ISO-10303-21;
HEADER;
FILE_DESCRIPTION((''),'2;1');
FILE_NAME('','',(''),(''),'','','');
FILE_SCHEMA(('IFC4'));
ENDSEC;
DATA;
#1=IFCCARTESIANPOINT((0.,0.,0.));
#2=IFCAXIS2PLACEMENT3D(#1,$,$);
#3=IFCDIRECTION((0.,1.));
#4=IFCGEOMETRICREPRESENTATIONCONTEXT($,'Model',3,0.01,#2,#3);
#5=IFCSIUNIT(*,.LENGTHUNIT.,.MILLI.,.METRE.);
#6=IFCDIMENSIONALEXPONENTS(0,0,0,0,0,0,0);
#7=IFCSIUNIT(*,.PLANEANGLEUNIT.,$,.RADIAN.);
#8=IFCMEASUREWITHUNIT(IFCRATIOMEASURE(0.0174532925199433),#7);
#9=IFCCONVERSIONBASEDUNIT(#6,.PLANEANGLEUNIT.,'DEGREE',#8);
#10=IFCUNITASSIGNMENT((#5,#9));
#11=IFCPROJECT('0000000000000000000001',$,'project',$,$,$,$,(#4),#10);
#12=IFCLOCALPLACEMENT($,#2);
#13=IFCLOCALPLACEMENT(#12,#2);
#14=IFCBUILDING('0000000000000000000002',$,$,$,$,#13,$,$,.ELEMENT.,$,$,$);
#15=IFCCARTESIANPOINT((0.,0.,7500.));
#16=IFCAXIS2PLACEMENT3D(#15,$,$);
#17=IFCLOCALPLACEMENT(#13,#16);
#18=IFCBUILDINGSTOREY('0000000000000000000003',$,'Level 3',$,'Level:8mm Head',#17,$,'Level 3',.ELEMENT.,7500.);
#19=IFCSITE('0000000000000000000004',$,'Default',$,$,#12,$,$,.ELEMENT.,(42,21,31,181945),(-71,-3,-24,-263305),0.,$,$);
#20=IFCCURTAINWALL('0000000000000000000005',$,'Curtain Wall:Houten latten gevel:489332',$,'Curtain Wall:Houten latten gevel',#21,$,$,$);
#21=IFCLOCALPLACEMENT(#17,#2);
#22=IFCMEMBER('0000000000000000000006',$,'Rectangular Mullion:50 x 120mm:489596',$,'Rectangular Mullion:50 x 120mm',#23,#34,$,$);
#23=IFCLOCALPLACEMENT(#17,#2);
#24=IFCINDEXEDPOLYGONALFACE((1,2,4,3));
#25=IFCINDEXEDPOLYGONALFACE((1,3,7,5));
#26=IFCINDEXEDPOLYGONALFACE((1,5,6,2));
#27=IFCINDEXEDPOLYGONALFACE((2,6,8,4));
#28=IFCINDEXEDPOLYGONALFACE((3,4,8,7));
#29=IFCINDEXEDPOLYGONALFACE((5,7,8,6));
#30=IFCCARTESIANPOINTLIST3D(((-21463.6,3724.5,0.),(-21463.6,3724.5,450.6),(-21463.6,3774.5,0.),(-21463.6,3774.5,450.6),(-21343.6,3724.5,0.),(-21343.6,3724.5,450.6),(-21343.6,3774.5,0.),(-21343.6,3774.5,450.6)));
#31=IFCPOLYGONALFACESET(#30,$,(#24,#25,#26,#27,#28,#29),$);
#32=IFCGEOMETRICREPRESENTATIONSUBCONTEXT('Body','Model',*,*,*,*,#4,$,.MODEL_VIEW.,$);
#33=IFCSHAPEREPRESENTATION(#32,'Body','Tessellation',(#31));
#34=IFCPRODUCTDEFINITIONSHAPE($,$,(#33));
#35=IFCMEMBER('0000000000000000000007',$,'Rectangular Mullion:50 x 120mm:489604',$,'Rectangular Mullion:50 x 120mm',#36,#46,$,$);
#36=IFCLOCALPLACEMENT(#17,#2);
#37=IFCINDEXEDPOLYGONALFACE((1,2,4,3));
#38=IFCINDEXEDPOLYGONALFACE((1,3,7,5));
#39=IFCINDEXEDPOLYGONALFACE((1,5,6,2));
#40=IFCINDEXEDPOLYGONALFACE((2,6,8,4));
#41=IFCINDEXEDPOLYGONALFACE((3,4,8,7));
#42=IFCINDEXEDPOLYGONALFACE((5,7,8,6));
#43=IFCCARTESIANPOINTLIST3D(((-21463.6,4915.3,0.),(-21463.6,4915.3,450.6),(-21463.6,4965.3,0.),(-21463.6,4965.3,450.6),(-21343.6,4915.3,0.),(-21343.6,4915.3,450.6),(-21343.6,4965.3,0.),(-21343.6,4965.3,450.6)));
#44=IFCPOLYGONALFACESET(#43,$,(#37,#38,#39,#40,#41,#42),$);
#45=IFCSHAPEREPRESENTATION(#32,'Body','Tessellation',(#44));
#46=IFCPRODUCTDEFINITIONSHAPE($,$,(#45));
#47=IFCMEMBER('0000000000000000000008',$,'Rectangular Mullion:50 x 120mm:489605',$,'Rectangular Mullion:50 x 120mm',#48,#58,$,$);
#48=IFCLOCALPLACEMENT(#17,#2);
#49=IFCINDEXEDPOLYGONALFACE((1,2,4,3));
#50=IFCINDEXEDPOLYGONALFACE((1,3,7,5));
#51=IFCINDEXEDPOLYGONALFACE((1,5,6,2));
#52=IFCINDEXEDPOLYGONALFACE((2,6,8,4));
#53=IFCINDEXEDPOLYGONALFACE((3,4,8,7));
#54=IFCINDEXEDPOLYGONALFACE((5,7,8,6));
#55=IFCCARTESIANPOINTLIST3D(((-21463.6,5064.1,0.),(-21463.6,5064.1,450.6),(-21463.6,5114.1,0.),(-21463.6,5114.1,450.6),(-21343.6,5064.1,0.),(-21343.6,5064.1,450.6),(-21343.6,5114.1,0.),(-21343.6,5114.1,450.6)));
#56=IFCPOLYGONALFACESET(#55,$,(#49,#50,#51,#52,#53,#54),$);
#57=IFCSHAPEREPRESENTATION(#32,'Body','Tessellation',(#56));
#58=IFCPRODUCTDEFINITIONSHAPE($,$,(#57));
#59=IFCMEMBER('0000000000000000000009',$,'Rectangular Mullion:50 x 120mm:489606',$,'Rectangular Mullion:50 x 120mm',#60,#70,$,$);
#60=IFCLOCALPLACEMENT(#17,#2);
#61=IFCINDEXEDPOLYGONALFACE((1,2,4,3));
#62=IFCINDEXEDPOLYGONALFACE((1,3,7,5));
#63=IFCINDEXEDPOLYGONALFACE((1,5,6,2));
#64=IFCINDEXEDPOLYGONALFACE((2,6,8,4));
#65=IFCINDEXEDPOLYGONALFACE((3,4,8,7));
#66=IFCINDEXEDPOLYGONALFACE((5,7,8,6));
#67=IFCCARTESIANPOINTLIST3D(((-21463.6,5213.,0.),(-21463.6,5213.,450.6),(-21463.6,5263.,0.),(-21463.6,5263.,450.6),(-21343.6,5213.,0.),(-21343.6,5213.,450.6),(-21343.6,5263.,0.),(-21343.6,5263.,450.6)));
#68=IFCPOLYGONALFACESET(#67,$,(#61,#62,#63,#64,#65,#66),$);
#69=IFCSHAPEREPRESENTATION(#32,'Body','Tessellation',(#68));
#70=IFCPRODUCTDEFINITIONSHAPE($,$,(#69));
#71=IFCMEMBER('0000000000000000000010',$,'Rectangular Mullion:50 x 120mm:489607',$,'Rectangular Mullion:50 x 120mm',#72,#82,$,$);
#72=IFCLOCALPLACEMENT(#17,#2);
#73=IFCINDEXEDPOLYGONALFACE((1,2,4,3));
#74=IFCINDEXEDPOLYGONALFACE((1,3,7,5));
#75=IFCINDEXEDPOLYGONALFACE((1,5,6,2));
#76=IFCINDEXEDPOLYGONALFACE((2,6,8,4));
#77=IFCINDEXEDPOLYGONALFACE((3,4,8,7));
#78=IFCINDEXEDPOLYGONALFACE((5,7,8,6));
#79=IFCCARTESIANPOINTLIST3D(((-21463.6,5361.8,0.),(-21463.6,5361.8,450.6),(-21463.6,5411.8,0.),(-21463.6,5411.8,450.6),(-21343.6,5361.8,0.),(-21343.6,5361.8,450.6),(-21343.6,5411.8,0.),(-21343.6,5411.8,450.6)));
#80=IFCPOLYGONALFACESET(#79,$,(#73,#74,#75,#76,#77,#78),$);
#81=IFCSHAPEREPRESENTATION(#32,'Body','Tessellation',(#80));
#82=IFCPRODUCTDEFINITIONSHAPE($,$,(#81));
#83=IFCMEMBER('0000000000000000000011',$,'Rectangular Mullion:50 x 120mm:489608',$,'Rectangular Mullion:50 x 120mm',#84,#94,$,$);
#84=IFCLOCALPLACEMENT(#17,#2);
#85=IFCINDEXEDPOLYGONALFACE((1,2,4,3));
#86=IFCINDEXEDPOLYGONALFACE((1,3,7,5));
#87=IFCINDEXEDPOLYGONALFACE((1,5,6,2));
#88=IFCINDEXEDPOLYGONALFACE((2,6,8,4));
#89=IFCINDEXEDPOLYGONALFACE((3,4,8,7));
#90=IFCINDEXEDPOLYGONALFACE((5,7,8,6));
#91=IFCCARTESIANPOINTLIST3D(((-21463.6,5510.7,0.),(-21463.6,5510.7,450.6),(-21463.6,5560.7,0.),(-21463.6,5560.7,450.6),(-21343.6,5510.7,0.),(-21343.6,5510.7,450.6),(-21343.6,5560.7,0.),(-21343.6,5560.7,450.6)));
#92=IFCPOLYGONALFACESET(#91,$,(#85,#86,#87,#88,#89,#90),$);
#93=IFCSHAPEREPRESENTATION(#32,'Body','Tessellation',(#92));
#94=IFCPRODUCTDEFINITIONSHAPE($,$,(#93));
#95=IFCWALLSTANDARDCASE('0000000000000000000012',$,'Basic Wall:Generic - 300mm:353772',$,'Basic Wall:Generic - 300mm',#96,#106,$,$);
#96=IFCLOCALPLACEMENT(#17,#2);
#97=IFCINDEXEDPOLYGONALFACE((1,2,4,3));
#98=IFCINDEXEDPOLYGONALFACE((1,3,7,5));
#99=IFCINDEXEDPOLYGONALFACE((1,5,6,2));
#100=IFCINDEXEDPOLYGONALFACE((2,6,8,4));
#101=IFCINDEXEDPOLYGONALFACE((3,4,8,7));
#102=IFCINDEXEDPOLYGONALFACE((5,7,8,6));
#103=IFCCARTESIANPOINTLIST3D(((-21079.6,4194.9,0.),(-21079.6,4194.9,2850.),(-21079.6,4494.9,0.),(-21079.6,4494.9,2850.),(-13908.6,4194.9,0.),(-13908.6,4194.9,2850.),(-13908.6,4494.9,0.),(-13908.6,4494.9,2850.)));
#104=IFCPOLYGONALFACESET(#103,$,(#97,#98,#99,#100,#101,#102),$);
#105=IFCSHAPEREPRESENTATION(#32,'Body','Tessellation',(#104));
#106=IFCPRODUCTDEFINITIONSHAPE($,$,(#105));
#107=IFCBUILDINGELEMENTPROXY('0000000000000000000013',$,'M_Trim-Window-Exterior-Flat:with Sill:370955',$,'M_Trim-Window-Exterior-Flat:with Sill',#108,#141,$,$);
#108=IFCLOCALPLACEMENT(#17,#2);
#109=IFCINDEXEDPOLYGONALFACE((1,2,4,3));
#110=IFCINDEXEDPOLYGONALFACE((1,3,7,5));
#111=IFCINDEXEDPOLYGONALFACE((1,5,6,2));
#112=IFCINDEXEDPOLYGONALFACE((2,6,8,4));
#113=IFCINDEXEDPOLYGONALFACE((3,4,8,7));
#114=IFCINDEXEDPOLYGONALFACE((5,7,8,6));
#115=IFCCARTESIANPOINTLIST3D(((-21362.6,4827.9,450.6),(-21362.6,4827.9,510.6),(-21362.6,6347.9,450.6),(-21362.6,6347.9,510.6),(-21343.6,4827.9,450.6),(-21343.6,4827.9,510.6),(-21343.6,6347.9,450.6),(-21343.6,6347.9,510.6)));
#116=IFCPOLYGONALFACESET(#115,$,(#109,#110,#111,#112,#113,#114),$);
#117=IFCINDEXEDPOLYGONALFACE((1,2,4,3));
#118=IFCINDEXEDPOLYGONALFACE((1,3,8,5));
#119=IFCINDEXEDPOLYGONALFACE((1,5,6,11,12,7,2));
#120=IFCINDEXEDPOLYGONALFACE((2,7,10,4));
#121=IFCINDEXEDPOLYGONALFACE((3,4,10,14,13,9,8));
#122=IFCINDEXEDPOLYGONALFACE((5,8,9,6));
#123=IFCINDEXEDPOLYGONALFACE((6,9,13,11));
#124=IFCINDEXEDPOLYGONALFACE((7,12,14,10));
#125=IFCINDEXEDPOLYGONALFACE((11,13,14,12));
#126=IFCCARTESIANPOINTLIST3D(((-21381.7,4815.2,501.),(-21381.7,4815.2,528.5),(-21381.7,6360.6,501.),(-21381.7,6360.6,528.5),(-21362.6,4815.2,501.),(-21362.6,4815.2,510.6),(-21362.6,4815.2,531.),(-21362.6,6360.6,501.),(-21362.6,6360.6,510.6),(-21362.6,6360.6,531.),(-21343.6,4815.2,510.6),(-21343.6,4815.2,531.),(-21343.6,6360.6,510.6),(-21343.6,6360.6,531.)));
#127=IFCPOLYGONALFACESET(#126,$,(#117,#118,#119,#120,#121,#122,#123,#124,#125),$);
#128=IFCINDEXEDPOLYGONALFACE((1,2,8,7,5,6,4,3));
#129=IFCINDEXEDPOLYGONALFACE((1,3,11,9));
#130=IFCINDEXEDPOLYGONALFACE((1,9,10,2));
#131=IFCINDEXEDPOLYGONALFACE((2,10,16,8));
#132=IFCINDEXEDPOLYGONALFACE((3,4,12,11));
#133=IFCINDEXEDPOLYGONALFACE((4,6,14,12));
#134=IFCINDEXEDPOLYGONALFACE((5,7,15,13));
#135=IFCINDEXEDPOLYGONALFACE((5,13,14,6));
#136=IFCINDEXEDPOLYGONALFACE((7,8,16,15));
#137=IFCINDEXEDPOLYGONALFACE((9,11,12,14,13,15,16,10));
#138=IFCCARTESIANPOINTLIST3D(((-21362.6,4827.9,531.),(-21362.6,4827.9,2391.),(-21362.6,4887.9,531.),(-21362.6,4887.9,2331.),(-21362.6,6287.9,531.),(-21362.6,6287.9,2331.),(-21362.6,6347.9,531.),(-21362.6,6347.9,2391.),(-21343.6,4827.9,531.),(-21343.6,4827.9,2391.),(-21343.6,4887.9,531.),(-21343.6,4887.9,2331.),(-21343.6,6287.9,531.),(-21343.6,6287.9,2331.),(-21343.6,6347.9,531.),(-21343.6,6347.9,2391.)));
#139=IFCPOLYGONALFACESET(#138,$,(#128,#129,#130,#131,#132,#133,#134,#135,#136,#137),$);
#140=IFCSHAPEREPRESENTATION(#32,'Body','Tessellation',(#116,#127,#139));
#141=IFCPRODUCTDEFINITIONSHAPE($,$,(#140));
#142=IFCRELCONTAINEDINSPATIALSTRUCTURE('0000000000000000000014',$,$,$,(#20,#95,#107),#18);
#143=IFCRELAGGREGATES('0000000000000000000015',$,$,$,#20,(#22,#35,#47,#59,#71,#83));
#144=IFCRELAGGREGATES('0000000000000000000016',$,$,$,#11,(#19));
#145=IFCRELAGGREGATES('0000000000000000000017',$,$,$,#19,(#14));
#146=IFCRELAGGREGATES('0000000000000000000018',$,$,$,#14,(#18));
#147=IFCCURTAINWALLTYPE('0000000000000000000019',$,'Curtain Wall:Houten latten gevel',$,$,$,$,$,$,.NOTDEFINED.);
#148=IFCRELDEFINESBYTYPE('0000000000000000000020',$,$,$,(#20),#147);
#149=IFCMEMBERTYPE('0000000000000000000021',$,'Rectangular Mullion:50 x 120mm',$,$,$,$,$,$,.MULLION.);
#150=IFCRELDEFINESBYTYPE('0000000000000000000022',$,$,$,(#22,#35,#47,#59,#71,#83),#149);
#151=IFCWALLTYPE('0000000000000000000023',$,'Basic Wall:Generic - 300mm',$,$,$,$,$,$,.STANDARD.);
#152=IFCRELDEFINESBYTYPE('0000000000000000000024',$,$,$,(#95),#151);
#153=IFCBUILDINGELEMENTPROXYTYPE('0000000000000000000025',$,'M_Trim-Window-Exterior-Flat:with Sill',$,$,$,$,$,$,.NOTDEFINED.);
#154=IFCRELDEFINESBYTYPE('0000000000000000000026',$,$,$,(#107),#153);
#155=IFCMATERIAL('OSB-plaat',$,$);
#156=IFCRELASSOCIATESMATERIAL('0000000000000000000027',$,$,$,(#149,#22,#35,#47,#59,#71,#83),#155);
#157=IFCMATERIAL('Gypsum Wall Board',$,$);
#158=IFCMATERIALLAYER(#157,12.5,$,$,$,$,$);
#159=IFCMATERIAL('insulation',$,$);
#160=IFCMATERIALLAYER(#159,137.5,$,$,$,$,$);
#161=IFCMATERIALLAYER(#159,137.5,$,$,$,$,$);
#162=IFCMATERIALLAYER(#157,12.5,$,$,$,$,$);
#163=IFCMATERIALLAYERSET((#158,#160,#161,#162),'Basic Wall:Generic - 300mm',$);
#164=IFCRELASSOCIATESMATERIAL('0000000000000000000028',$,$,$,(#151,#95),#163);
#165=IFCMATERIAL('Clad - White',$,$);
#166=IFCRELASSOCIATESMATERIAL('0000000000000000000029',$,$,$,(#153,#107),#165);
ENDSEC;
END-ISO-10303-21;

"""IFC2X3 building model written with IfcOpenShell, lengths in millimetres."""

from ifc_helpers import new_model, entity, si_unit, converted_unit, direction, frame, frame_2d, origin, origin_2d_with_axis, place, context, subcontext, project, spatial, polyline, rectangle, outline, extrude, source, transform, mapped, material, layer, layer_set, layer_usage, type_object, type_shapes, element, aggregate, save


model = new_model("IFC2X3")

# Units and contexts
model_context = context("Model", 3, precision=0.01, world=origin(), true_north=direction((0.0, 1.0)))
body_context = subcontext(model_context, "Body", "Model", "MODEL_VIEW")
ifc_project = project(units=[si_unit("LENGTHUNIT", "METRE", prefix="MILLI"), converted_unit("PLANEANGLEUNIT", "DEGREE", entity("IfcRatioMeasure", 0.0174532925199433), si_unit("PLANEANGLEUNIT", "RADIAN"), dimensions=[0, 0, 0, 0, 0, 0, 0])], contexts=[model_context])

# Site, building, storey
site_placement = place(None, frame((0.0, 0.0, 0.0)))
site = spatial("IfcSite", under=ifc_project, at=site_placement, Name="Default", CompositionType="ELEMENT", RefLatitude=(42, 21, 31, 181945), RefLongitude=(-71, -3, -24, -263305), RefElevation=0.0)
building_placement = place(site_placement, origin())
building = spatial("IfcBuilding", under=site, at=building_placement, CompositionType="ELEMENT")
storey_placement = place(building_placement, frame((0.0, 0.0, 7500.0)))
storey = spatial("IfcBuildingStorey", under=building, at=storey_placement, Name="Level 3", ObjectType="Level:8mm Head", LongName="Level 3", CompositionType="ELEMENT", Elevation=7500.0)

# Curtain wall, members
curtain_wall_type = type_object("IfcCurtainWallType", Name="Curtain Wall:Houten latten gevel", PredefinedType="NOTDEFINED")
curtain_wall_placement = place(storey_placement, frame((0.0, 0.0, -7500.0)))
curtain_wall = element("IfcCurtainWall", 1, at=curtain_wall_placement, inside=storey, type_object=curtain_wall_type, Name="Curtain Wall:Houten latten gevel:489332", ObjectType="Curtain Wall:Houten latten gevel")
ifc_material_1 = material(Name="OSB-plaat")
member_type_1 = type_object("IfcMemberType", Name="Rectangular Mullion:50 x 120mm", PredefinedType="MULLION", material=ifc_material_1)
shared_shape_1 = source(origin(), body_context, "Body", "SweptSolid", [
    extrude(rectangle(XDim=120.0, YDim=50.0, at=origin_2d_with_axis()), frame((0.0, 0.0, -450.6), z_axis=(0.0, 0.0, 1.0), x_axis=(0.0, -1.0, 0.0)), (0.0, 0.0, 1.0), 450.6),
])
type_shapes(member_type_1, [shared_shape_1])
member_1_placement = place(storey_placement, frame((-21403.6, 3749.5, 0.0), z_axis=(0.0, 0.0, -1.0), x_axis=(0.0, 1.0, 0.0)))
member_1 = element("IfcMember", 2, at=member_1_placement, type_object=member_type_1, material=ifc_material_1, Name="Rectangular Mullion:50 x 120mm:489596", ObjectType="Rectangular Mullion:50 x 120mm", context=body_context, shape_type="MappedRepresentation", body=[
    mapped(shared_shape_1, transform((0.0, 0.0, 0.0), scale=1.0)),
])
member_2_placement = place(storey_placement, frame((-21403.6, 4940.3, 0.0), z_axis=(0.0, 0.0, -1.0), x_axis=(0.0, 1.0, 0.0)))
member_2 = element("IfcMember", 3, at=member_2_placement, type_object=member_type_1, material=ifc_material_1, Name="Rectangular Mullion:50 x 120mm:489604", ObjectType="Rectangular Mullion:50 x 120mm", context=body_context, shape_type="MappedRepresentation", body=[
    mapped(shared_shape_1, transform((0.0, 0.0, 0.0), scale=1.0)),
])
member_3_placement = place(storey_placement, frame((-21403.6, 5089.1, 0.0), z_axis=(0.0, 0.0, -1.0), x_axis=(0.0, 1.0, 0.0)))
member_3 = element("IfcMember", 4, at=member_3_placement, type_object=member_type_1, material=ifc_material_1, Name="Rectangular Mullion:50 x 120mm:489605", ObjectType="Rectangular Mullion:50 x 120mm", context=body_context, shape_type="MappedRepresentation", body=[
    mapped(shared_shape_1, transform((0.0, 0.0, 0.0), scale=1.0)),
])
member_4_placement = place(storey_placement, frame((-21403.6, 5238.0, 0.0), z_axis=(0.0, 0.0, -1.0), x_axis=(0.0, 1.0, 0.0)))
member_4 = element("IfcMember", 5, at=member_4_placement, type_object=member_type_1, material=ifc_material_1, Name="Rectangular Mullion:50 x 120mm:489606", ObjectType="Rectangular Mullion:50 x 120mm", context=body_context, shape_type="MappedRepresentation", body=[
    mapped(shared_shape_1, transform((0.0, 0.0, 0.0), scale=1.0)),
])
member_5_placement = place(storey_placement, frame((-21403.6, 5386.8, 0.0), z_axis=(0.0, 0.0, -1.0), x_axis=(0.0, 1.0, 0.0)))
member_5 = element("IfcMember", 6, at=member_5_placement, type_object=member_type_1, material=ifc_material_1, Name="Rectangular Mullion:50 x 120mm:489607", ObjectType="Rectangular Mullion:50 x 120mm", context=body_context, shape_type="MappedRepresentation", body=[
    mapped(shared_shape_1, transform((0.0, 0.0, 0.0), scale=1.0)),
])
member_6_placement = place(storey_placement, frame((-21403.6, 5535.7, 0.0), z_axis=(0.0, 0.0, -1.0), x_axis=(0.0, 1.0, 0.0)))
member_6 = element("IfcMember", 7, at=member_6_placement, type_object=member_type_1, material=ifc_material_1, Name="Rectangular Mullion:50 x 120mm:489608", ObjectType="Rectangular Mullion:50 x 120mm", context=body_context, shape_type="MappedRepresentation", body=[
    mapped(shared_shape_1, transform((0.0, 0.0, 0.0), scale=1.0)),
])
aggregate(curtain_wall, [member_1, member_2, member_3, member_4, member_5, member_6])

# Wall
ifc_material_2 = material(Name="Gypsum Wall Board")
ifc_layer_1 = layer(ifc_material_2, 12.5)
ifc_material_3 = material(Name="insulation")
ifc_layer_2 = layer(ifc_material_3, 137.5)
ifc_layer_3 = layer(ifc_material_3, 137.5)
ifc_layer_4 = layer(ifc_material_2, 12.5)
ifc_layer_set = layer_set([ifc_layer_1, ifc_layer_2, ifc_layer_3, ifc_layer_4], Name="Basic Wall:Generic - 300mm")
ifc_layer_usage = layer_usage(ifc_layer_set, "AXIS2", "NEGATIVE", 150.0)
wall_type = type_object("IfcWallType", Name="Basic Wall:Generic - 300mm", PredefinedType="STANDARD", material=ifc_layer_set)
wall_placement = place(storey_placement, frame((-21079.6, 4344.9, 0.0)))
element("IfcWallStandardCase", 8, at=wall_placement, inside=storey, type_object=wall_type, material=ifc_layer_usage, Name="Basic Wall:Generic - 300mm:353772", ObjectType="Basic Wall:Generic - 300mm", context=body_context, shape_type="SweptSolid", body=[
    extrude(rectangle(XDim=7171.0, YDim=300.0, at=frame_2d((3585.5, 0.0), x_axis=(-1.0, 0.0))), origin(), (0.0, 0.0, 1.0), 2850.0),
])

# Building element proxy
ifc_material_4 = material(Name="Clad - White")
building_element_proxy_type = type_object("IfcBuildingElementProxyType", Name="M_Trim-Window-Exterior-Flat:with Sill", PredefinedType="NOTDEFINED", material=ifc_material_4)
shared_shape_2 = source(origin(), body_context, "Body", "SweptSolid", [
    extrude(rectangle(XDim=1520.0, YDim=60.0, at=frame_2d((0.0, 0.0), x_axis=(1.0, 0.0))), frame((0.0, -1850.4, 0.0), z_axis=(0.0, 0.0, 1.0), x_axis=(-1.0, 0.0, 0.0)), (0.0, 0.0, 1.0), 19.1),
    extrude(outline(polyline([(-19.0, -15.2), (0.0, -15.2), (0.0, -5.7), (19.0, -5.7), (19.0, 14.8), (0.0, 14.8), (-19.0, 12.3), (-19.0, -15.2)])), frame((-772.7, -1814.8, 19.0), z_axis=(1.0, 0.0, 0.0), x_axis=(0.0, 0.0, -1.0)), (0.0, 0.0, 1.0), 1545.4),
    extrude(outline(polyline([(-945.0, -760.0), (915.0, -760.0), (915.0, -700.0), (-885.0, -700.0), (-885.0, 700.0), (915.0, 700.0), (915.0, 760.0), (-945.0, 760.0), (-945.0, -760.0)])), frame((0.0, -885.0, 0.0), z_axis=(0.0, 0.0, 1.0), x_axis=(0.0, -1.0, 0.0)), (0.0, 0.0, 1.0), 19.1),
])
type_shapes(building_element_proxy_type, [shared_shape_2])
proxy_placement = place(storey_placement, frame((-21343.6, 5587.9, 2331.0), z_axis=(-1.0, 0.0, 0.0), x_axis=(0.0, -1.0, 0.0)))
element("IfcBuildingElementProxy", 9, at=proxy_placement, inside=storey, type_object=building_element_proxy_type, material=ifc_material_4, Name="M_Trim-Window-Exterior-Flat:with Sill:370955", ObjectType="M_Trim-Window-Exterior-Flat:with Sill", context=body_context, shape_type="MappedRepresentation", body=[
    mapped(shared_shape_2, transform((0.0, 0.0, 0.0), scale=1.0)),
])

save(model, "model.ifc")
